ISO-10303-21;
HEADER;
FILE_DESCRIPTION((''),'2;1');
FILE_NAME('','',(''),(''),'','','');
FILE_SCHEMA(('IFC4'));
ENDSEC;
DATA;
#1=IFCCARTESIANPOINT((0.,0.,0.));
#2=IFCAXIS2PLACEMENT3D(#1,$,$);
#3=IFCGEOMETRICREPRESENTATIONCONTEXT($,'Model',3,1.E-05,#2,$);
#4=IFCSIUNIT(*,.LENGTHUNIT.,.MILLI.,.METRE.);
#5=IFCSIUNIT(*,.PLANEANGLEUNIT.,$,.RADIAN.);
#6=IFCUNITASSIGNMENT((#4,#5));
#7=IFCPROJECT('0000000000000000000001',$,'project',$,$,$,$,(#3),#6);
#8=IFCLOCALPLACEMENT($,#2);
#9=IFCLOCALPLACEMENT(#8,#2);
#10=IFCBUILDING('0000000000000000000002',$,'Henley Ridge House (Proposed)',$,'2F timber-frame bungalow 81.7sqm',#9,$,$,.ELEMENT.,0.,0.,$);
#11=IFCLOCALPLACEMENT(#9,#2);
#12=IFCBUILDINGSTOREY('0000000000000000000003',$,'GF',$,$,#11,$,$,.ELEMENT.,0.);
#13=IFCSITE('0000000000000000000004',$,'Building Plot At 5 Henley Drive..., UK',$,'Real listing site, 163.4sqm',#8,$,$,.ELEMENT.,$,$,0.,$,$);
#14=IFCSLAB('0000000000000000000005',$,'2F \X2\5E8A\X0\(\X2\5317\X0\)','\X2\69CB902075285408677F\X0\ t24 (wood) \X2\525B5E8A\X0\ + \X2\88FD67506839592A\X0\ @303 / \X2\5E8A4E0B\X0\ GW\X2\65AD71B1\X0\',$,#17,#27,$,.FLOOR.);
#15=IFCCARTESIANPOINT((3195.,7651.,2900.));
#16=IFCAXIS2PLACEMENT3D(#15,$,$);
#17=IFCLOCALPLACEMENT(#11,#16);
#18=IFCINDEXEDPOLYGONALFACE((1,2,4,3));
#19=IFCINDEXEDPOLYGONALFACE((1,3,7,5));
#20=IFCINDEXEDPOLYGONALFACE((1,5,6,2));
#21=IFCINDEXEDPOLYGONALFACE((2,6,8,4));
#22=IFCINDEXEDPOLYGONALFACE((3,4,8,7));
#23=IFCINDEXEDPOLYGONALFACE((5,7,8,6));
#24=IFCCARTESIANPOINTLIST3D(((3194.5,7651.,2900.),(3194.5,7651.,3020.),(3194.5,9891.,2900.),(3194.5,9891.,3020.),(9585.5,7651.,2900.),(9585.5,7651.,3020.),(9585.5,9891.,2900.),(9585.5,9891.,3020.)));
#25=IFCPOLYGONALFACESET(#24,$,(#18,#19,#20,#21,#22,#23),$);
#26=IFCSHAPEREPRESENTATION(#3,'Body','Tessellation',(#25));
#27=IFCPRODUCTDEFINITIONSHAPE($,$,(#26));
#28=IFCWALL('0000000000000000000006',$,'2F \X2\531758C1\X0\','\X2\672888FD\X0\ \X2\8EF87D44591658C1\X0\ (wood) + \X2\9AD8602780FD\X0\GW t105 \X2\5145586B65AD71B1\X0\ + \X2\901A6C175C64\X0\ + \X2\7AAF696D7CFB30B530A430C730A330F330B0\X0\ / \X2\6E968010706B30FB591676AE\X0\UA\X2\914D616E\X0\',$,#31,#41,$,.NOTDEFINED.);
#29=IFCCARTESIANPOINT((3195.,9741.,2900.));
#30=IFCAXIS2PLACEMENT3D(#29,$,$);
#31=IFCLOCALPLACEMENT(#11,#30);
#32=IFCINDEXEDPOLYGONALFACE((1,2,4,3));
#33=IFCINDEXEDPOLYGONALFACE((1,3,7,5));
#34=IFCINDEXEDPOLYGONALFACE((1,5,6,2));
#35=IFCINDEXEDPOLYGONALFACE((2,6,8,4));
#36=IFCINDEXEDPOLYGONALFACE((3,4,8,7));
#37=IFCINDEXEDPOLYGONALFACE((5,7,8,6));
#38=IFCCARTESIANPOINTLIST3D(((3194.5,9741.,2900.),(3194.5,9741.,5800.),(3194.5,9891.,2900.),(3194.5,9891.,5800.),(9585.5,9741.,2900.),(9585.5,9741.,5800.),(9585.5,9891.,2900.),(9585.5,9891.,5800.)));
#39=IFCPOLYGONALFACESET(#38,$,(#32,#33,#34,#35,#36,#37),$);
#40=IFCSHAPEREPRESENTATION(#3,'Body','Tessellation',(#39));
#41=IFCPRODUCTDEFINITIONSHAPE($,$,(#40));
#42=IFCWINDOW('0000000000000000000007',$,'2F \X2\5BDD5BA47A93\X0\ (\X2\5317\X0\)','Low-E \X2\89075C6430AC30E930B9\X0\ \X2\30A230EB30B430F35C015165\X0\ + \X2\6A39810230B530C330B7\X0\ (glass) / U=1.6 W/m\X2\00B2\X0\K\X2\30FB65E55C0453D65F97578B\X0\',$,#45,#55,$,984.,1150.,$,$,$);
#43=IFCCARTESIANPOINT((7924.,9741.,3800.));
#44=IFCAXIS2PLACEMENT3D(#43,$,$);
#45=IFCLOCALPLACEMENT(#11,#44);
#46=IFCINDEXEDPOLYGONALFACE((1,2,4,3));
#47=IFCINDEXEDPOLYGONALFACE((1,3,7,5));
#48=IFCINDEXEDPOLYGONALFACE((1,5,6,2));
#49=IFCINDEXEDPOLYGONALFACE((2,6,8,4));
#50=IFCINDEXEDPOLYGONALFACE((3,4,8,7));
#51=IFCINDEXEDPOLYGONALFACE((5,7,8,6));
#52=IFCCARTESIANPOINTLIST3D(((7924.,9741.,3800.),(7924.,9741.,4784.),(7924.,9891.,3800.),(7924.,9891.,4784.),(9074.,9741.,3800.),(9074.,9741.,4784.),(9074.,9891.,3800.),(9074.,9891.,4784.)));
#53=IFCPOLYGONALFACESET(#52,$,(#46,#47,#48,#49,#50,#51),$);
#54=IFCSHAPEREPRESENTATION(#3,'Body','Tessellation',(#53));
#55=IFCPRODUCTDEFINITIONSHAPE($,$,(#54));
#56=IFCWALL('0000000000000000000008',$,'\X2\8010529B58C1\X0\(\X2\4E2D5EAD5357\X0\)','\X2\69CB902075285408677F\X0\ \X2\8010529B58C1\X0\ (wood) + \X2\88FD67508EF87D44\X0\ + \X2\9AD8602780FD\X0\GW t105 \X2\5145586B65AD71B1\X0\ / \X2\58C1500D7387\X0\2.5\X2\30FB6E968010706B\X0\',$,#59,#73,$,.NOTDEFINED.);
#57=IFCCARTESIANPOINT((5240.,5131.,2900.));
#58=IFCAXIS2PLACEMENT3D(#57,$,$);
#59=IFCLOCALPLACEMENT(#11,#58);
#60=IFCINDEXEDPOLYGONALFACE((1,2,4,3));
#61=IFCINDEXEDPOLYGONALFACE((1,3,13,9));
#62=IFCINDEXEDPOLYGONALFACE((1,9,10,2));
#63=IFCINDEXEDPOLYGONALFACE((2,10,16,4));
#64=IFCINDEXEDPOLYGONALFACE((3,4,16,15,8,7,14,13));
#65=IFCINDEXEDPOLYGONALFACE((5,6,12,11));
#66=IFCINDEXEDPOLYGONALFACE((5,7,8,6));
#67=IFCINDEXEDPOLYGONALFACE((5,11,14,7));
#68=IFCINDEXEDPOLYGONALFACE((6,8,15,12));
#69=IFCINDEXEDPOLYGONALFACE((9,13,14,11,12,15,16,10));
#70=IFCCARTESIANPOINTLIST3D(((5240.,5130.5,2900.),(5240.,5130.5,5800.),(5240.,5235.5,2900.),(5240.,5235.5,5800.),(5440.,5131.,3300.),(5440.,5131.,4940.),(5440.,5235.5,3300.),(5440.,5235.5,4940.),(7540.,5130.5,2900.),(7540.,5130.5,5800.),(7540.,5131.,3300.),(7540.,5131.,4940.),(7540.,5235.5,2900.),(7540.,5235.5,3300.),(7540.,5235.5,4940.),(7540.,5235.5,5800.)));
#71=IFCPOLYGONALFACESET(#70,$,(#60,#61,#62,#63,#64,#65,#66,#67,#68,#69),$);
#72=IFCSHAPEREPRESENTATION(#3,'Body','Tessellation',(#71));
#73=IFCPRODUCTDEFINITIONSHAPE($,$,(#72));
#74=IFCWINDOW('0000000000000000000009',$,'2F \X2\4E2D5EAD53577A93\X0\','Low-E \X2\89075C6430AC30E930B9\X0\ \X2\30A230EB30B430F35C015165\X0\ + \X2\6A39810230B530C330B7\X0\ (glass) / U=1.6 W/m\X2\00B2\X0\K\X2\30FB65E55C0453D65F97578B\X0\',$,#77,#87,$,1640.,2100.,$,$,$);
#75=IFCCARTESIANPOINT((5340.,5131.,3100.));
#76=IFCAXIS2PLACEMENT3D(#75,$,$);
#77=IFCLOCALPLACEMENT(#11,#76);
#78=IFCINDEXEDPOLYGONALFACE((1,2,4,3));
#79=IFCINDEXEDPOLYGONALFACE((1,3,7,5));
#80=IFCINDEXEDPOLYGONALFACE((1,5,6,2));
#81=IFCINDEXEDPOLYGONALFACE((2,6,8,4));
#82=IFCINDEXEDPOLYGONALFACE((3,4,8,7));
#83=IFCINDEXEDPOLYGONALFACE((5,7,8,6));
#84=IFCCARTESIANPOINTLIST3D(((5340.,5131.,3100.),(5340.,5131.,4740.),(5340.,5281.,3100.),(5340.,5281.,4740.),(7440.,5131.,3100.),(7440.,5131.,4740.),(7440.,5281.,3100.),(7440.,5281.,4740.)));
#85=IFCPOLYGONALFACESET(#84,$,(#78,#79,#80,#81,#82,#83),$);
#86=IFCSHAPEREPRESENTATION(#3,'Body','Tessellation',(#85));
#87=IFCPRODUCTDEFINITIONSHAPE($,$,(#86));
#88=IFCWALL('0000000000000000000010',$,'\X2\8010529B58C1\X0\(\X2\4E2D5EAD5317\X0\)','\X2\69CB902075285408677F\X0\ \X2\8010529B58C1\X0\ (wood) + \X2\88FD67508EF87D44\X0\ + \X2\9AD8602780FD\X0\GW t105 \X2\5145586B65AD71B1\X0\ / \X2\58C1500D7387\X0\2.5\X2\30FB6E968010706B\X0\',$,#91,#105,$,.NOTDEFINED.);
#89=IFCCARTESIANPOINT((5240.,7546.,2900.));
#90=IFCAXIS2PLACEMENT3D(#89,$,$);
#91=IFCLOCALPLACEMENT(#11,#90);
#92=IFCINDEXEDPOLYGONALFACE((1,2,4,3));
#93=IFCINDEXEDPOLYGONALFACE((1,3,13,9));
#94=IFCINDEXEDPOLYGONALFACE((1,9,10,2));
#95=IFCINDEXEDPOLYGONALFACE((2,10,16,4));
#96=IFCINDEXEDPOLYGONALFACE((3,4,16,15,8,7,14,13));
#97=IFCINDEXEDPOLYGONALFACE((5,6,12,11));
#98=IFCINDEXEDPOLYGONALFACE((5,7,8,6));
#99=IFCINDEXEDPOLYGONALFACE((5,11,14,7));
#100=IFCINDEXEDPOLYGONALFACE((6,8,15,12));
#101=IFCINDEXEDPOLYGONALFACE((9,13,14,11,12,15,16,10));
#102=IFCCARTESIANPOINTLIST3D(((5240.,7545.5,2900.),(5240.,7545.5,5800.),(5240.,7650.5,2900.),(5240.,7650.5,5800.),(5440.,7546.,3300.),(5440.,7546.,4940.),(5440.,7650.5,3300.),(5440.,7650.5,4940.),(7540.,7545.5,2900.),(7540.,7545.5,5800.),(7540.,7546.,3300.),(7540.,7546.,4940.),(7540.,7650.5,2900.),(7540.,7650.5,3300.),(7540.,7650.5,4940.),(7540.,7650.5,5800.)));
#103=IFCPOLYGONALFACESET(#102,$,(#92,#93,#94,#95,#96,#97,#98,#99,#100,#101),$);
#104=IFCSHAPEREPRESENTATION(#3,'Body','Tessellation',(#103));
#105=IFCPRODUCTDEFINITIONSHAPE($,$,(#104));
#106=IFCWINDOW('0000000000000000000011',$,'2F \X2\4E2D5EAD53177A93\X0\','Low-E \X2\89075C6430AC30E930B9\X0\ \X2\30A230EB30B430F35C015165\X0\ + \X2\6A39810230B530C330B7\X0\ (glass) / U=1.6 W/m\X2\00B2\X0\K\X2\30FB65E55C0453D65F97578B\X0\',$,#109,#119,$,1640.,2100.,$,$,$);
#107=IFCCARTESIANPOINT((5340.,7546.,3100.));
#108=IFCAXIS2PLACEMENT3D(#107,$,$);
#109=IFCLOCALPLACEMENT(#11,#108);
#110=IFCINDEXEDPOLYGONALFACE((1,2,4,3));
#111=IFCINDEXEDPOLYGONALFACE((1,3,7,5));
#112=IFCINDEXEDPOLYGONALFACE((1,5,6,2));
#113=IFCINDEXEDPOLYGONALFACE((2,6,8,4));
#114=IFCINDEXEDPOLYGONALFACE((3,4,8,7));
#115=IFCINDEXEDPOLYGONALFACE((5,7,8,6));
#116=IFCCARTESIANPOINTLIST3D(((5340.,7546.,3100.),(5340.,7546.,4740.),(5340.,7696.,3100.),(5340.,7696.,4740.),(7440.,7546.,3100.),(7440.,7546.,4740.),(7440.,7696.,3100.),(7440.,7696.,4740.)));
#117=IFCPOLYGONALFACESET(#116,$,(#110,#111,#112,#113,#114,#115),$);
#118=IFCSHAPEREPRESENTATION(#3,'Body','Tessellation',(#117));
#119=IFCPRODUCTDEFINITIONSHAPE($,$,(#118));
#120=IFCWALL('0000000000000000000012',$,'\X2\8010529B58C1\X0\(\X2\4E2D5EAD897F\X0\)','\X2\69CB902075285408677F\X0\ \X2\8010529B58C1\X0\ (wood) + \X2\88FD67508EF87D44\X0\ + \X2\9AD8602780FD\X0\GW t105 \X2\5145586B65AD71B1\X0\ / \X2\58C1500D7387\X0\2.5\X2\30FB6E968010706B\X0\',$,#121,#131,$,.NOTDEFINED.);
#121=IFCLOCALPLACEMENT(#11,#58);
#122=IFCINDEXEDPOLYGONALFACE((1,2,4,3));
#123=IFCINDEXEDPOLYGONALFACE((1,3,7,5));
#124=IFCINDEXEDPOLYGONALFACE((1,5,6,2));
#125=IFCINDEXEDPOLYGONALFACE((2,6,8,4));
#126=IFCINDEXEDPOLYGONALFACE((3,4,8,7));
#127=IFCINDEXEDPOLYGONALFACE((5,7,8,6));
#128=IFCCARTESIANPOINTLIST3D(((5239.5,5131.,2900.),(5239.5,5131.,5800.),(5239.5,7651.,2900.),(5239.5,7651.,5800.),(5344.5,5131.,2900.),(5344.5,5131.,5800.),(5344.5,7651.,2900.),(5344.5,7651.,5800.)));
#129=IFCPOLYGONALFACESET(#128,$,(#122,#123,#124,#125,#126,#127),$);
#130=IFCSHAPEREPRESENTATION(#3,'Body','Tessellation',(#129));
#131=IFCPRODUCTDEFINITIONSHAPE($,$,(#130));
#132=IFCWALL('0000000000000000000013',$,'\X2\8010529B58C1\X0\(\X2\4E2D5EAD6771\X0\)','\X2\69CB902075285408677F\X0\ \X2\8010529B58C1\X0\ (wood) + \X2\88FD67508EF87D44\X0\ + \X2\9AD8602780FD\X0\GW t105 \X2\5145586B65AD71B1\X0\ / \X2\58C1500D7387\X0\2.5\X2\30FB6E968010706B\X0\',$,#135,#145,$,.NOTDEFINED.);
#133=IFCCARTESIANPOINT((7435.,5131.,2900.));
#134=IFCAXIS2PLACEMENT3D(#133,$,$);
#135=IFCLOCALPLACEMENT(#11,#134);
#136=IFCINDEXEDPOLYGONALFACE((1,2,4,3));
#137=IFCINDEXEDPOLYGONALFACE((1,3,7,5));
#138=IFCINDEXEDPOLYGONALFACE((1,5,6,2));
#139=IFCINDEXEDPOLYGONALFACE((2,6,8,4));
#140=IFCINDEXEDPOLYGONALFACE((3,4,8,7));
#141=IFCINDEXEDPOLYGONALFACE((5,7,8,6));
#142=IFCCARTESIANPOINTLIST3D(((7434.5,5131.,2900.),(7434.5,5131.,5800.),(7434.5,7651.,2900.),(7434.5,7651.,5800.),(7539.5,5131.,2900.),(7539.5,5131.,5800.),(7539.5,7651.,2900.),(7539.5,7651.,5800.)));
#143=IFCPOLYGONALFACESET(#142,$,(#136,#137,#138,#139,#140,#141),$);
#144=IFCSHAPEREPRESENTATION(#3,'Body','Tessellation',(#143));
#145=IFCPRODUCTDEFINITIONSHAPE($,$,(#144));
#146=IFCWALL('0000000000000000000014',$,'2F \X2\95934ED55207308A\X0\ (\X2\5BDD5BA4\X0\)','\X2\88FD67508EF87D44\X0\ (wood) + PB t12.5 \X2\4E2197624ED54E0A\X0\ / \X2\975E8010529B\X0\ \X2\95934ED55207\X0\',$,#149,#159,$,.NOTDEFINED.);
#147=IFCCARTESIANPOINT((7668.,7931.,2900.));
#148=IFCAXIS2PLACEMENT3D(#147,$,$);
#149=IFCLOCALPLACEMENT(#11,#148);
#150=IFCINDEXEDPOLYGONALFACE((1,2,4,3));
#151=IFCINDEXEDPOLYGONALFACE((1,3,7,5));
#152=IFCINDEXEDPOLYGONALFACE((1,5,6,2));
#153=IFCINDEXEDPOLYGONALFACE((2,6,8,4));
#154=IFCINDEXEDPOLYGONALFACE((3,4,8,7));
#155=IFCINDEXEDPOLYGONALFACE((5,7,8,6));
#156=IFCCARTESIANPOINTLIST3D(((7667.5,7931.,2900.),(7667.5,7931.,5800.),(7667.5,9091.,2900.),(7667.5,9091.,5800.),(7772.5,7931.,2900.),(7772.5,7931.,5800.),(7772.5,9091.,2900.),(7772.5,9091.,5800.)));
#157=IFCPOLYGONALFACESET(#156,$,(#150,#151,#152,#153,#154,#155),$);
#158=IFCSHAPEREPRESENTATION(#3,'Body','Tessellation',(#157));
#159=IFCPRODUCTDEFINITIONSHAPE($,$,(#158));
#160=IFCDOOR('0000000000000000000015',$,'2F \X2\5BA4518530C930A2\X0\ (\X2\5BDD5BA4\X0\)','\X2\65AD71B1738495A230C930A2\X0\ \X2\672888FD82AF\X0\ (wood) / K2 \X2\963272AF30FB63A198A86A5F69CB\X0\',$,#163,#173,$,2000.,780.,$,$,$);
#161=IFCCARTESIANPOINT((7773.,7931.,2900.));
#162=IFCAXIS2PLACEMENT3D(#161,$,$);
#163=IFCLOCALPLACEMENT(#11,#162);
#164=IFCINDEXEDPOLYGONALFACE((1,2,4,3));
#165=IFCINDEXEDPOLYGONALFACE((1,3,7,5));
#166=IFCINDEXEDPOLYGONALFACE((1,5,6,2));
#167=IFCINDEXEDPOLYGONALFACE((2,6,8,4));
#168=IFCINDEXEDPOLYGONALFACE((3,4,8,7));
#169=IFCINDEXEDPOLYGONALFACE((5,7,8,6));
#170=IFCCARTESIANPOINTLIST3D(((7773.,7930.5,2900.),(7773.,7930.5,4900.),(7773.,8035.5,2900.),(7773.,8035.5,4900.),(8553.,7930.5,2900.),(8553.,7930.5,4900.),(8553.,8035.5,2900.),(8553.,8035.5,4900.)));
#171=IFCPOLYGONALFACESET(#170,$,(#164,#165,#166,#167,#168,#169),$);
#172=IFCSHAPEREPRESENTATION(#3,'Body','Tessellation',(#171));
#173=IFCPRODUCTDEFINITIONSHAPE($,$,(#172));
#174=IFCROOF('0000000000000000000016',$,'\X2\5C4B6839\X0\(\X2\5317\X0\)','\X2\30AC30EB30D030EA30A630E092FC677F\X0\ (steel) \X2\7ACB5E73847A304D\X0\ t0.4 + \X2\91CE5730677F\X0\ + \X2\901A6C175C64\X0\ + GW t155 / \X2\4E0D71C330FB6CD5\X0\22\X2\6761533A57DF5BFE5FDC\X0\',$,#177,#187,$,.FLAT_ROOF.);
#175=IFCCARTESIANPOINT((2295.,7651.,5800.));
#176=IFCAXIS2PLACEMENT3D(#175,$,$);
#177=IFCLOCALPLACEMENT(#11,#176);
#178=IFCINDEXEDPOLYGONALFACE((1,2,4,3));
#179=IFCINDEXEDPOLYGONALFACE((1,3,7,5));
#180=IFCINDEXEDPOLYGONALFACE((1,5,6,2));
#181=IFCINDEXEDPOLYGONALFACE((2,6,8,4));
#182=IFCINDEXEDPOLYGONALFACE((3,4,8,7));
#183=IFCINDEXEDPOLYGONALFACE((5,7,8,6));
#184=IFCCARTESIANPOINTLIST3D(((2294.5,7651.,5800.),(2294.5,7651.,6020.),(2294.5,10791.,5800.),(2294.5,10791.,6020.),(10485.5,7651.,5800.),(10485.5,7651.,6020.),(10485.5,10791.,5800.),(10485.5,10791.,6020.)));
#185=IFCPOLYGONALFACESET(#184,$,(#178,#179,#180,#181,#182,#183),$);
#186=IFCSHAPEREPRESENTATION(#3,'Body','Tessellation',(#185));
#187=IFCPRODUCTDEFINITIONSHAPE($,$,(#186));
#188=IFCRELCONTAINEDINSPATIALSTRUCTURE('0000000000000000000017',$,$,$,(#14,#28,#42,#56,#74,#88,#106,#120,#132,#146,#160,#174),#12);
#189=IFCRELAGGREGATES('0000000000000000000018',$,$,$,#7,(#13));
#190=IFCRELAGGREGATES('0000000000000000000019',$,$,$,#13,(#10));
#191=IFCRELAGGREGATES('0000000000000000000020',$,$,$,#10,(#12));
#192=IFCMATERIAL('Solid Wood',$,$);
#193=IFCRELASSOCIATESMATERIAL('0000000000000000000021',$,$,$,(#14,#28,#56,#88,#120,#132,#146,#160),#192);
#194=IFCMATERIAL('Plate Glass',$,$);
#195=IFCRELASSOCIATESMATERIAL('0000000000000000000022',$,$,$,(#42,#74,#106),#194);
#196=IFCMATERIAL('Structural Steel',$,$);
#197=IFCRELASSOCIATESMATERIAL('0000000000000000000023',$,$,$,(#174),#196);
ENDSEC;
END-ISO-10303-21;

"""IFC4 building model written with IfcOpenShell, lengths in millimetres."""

from ifc_helpers import new_model, si_unit, frame, frame_2d, origin, place, context, project, spatial, rectangle, extrude, material, element, fill, save


model = new_model("IFC4")

# Units and contexts
model_context = context("Model", 3, precision=1e-05, world=origin())
ifc_project = project(units=[si_unit("LENGTHUNIT", "METRE", prefix="MILLI"), si_unit("PLANEANGLEUNIT", "RADIAN")], contexts=[model_context])

# Site, building, storey
site_placement = place(None, origin())
site = spatial("IfcSite", under=ifc_project, at=site_placement, Name="Building Plot At 5 Henley Drive..., UK", ObjectType="Real listing site, 163.4sqm", CompositionType="ELEMENT", RefElevation=0.0)
building_placement = place(site_placement, origin())
building = spatial("IfcBuilding", under=site, at=building_placement, Name="Henley Ridge House (Proposed)", ObjectType="2F timber-frame bungalow 81.7sqm", CompositionType="ELEMENT", ElevationOfRefHeight=0.0, ElevationOfTerrain=0.0)
storey_placement = place(building_placement, origin())
storey = spatial("IfcBuildingStorey", under=building, at=storey_placement, Name="GF", CompositionType="ELEMENT", Elevation=0.0)

# Slab
ifc_material_1 = material(Name="Solid Wood")
slab_placement = place(storey_placement, frame((3195.0, 7651.0, 2900.0)))
element("IfcSlab", 1, at=slab_placement, inside=storey, material=ifc_material_1, Name="2F 床(北)", Description="構造用合板 t24 (wood) 剛床 + 製材根太 @303 / 床下 GW断熱", PredefinedType="FLOOR", context=model_context, shape_type="SweptSolid", body=[
    extrude(rectangle(XDim=6391.0, YDim=2240.0, at=frame_2d((3195.0, 1120.0))), frame((3195.0, 7651.0, 2900.0)), (0.0, 0.0, 1.0), 120.0),
])

# Walls, openings, windows
wall_1_placement = place(storey_placement, frame((3195.0, 9741.0, 2900.0)))
wall_1 = element("IfcWall", 2, at=wall_1_placement, inside=storey, material=ifc_material_1, Name="2F 北壁", Description="木製 軸組外壁 (wood) + 高性能GW t105 充填断熱 + 通気層 + 窯業系サイディング / 準耐火・外皮UA配慮", PredefinedType="NOTDEFINED", context=model_context, shape_type="SweptSolid", body=[
    extrude(rectangle(XDim=6391.0, YDim=150.0, at=frame_2d((3195.0, 75.0))), frame((3195.0, 9741.0, 2900.0)), (0.0, 0.0, 1.0), 2900.0),
])
opening_1_placement = place(storey_placement, frame((7924.0, 9741.0, 3800.0)))
opening_1 = element("IfcOpeningElement", 3, at=opening_1_placement, cuts=wall_1, PredefinedType="NOTDEFINED", context=model_context, shape_type="SweptSolid", body=[
    extrude(rectangle(XDim=1150.0, YDim=150.0, at=frame_2d((575.0, 75.0))), frame((7924.0, 9741.0, 3800.0)), (0.0, 0.0, 1.0), 984.0),
])
ifc_material_2 = material(Name="Plate Glass")
window_1_placement = place(storey_placement, frame((7924.0, 9741.0, 3800.0)))
window_1 = element("IfcWindow", 4, at=window_1_placement, inside=storey, material=ifc_material_2, Name="2F 寝室窓 (北)", Description="Low-E 複層ガラス アルゴン封入 + 樹脂サッシ (glass) / U=1.6 W/m²K・日射取得型", OverallHeight=984.0, OverallWidth=1150.0, context=model_context, shape_type="SweptSolid", body=[
    extrude(rectangle(XDim=1150.0, YDim=150.0, at=frame_2d((575.0, 75.0))), frame((7924.0, 9741.0, 3800.0)), (0.0, 0.0, 1.0), 984.0),
])
fill(opening_1, window_1)
wall_2_placement = place(storey_placement, frame((5240.0, 5131.0, 2900.0)))
wall_2 = element("IfcWall", 5, at=wall_2_placement, inside=storey, material=ifc_material_1, Name="耐力壁(中庭南)", Description="構造用合板 耐力壁 (wood) + 製材軸組 + 高性能GW t105 充填断熱 / 壁倍率2.5・準耐火", PredefinedType="NOTDEFINED", context=model_context, shape_type="SweptSolid", body=[
    extrude(rectangle(XDim=2300.0, YDim=105.0, at=frame_2d((1150.0, 52.0))), frame((5240.0, 5131.0, 2900.0)), (0.0, 0.0, 1.0), 2900.0),
])
opening_2_placement = place(storey_placement, frame((5340.0, 5131.0, 3100.0)))
opening_2 = element("IfcOpeningElement", 6, at=opening_2_placement, cuts=wall_2, PredefinedType="NOTDEFINED", context=model_context, shape_type="SweptSolid", body=[
    extrude(rectangle(XDim=2100.0, YDim=150.0, at=frame_2d((1050.0, 75.0))), frame((5340.0, 5131.0, 3100.0)), (0.0, 0.0, 1.0), 1640.0),
])
window_2_placement = place(storey_placement, frame((5340.0, 5131.0, 3100.0)))
window_2 = element("IfcWindow", 7, at=window_2_placement, inside=storey, material=ifc_material_2, Name="2F 中庭南窓", Description="Low-E 複層ガラス アルゴン封入 + 樹脂サッシ (glass) / U=1.6 W/m²K・日射取得型", OverallHeight=1640.0, OverallWidth=2100.0, context=model_context, shape_type="SweptSolid", body=[
    extrude(rectangle(XDim=2100.0, YDim=150.0, at=frame_2d((1050.0, 75.0))), frame((5340.0, 5131.0, 3100.0)), (0.0, 0.0, 1.0), 1640.0),
])
fill(opening_2, window_2)
wall_3_placement = place(storey_placement, frame((5240.0, 7546.0, 2900.0)))
wall_3 = element("IfcWall", 8, at=wall_3_placement, inside=storey, material=ifc_material_1, Name="耐力壁(中庭北)", Description="構造用合板 耐力壁 (wood) + 製材軸組 + 高性能GW t105 充填断熱 / 壁倍率2.5・準耐火", PredefinedType="NOTDEFINED", context=model_context, shape_type="SweptSolid", body=[
    extrude(rectangle(XDim=2300.0, YDim=105.0, at=frame_2d((1150.0, 52.0))), frame((5240.0, 7546.0, 2900.0)), (0.0, 0.0, 1.0), 2900.0),
])
opening_3_placement = place(storey_placement, frame((5340.0, 7546.0, 3100.0)))
opening_3 = element("IfcOpeningElement", 9, at=opening_3_placement, cuts=wall_3, PredefinedType="NOTDEFINED", context=model_context, shape_type="SweptSolid", body=[
    extrude(rectangle(XDim=2100.0, YDim=150.0, at=frame_2d((1050.0, 75.0))), frame((5340.0, 7546.0, 3100.0)), (0.0, 0.0, 1.0), 1640.0),
])
window_3_placement = place(storey_placement, frame((5340.0, 7546.0, 3100.0)))
window_3 = element("IfcWindow", 10, at=window_3_placement, inside=storey, material=ifc_material_2, Name="2F 中庭北窓", Description="Low-E 複層ガラス アルゴン封入 + 樹脂サッシ (glass) / U=1.6 W/m²K・日射取得型", OverallHeight=1640.0, OverallWidth=2100.0, context=model_context, shape_type="SweptSolid", body=[
    extrude(rectangle(XDim=2100.0, YDim=150.0, at=frame_2d((1050.0, 75.0))), frame((5340.0, 7546.0, 3100.0)), (0.0, 0.0, 1.0), 1640.0),
])
fill(opening_3, window_3)

# Walls
wall_4_placement = place(storey_placement, frame((5240.0, 5131.0, 2900.0)))
element("IfcWall", 11, at=wall_4_placement, inside=storey, material=ifc_material_1, Name="耐力壁(中庭西)", Description="構造用合板 耐力壁 (wood) + 製材軸組 + 高性能GW t105 充填断熱 / 壁倍率2.5・準耐火", PredefinedType="NOTDEFINED", context=model_context, shape_type="SweptSolid", body=[
    extrude(rectangle(XDim=105.0, YDim=2520.0, at=frame_2d((52.0, 1260.0))), frame((5240.0, 5131.0, 2900.0)), (0.0, 0.0, 1.0), 2900.0),
])
wall_5_placement = place(storey_placement, frame((7435.0, 5131.0, 2900.0)))
element("IfcWall", 12, at=wall_5_placement, inside=storey, material=ifc_material_1, Name="耐力壁(中庭東)", Description="構造用合板 耐力壁 (wood) + 製材軸組 + 高性能GW t105 充填断熱 / 壁倍率2.5・準耐火", PredefinedType="NOTDEFINED", context=model_context, shape_type="SweptSolid", body=[
    extrude(rectangle(XDim=105.0, YDim=2520.0, at=frame_2d((52.0, 1260.0))), frame((7435.0, 5131.0, 2900.0)), (0.0, 0.0, 1.0), 2900.0),
])
wall_6_placement = place(storey_placement, frame((7668.0, 7931.0, 2900.0)))
element("IfcWall", 13, at=wall_6_placement, inside=storey, material=ifc_material_1, Name="2F 間仕切り (寝室)", Description="製材軸組 (wood) + PB t12.5 両面仕上 / 非耐力 間仕切", PredefinedType="NOTDEFINED", context=model_context, shape_type="SweptSolid", body=[
    extrude(rectangle(XDim=105.0, YDim=1160.0, at=frame_2d((52.0, 580.0))), frame((7668.0, 7931.0, 2900.0)), (0.0, 0.0, 1.0), 2900.0),
])

# Door
door_placement = place(storey_placement, frame((7773.0, 7931.0, 2900.0)))
element("IfcDoor", 14, at=door_placement, inside=storey, material=ifc_material_1, Name="2F 室内ドア (寝室)", Description="断熱玄関ドア 木製芯 (wood) / K2 防犯・採風機構", OverallHeight=2000.0, OverallWidth=780.0, context=model_context, shape_type="SweptSolid", body=[
    extrude(rectangle(XDim=780.0, YDim=105.0, at=frame_2d((390.0, 52.0))), frame((7773.0, 7931.0, 2900.0)), (0.0, 0.0, 1.0), 2000.0),
])

# Roof
ifc_material_3 = material(Name="Structural Steel")
for number, where, name in (
    (15, (2295.0, 7651.0, 5800.0), "屋根(北)"),
):
    element("IfcRoof", number, at=place(storey_placement, frame(where)), inside=storey, material=ifc_material_3, Name=name, Description="ガルバリウム鋼板 (steel) 立平葺き t0.4 + 野地板 + 通気層 + GW t155 / 不燃・法22条区域対応", PredefinedType="FLAT_ROOF", context=model_context, shape_type="SweptSolid", body=[
        extrude(rectangle(XDim=8191.0, YDim=3140.0, at=frame_2d((4095.0, 1570.0))), frame((2295.0, 7651.0, 5800.0)), (0.0, 0.0, 1.0), 220.0),
    ])

save(model, "model.ifc")
